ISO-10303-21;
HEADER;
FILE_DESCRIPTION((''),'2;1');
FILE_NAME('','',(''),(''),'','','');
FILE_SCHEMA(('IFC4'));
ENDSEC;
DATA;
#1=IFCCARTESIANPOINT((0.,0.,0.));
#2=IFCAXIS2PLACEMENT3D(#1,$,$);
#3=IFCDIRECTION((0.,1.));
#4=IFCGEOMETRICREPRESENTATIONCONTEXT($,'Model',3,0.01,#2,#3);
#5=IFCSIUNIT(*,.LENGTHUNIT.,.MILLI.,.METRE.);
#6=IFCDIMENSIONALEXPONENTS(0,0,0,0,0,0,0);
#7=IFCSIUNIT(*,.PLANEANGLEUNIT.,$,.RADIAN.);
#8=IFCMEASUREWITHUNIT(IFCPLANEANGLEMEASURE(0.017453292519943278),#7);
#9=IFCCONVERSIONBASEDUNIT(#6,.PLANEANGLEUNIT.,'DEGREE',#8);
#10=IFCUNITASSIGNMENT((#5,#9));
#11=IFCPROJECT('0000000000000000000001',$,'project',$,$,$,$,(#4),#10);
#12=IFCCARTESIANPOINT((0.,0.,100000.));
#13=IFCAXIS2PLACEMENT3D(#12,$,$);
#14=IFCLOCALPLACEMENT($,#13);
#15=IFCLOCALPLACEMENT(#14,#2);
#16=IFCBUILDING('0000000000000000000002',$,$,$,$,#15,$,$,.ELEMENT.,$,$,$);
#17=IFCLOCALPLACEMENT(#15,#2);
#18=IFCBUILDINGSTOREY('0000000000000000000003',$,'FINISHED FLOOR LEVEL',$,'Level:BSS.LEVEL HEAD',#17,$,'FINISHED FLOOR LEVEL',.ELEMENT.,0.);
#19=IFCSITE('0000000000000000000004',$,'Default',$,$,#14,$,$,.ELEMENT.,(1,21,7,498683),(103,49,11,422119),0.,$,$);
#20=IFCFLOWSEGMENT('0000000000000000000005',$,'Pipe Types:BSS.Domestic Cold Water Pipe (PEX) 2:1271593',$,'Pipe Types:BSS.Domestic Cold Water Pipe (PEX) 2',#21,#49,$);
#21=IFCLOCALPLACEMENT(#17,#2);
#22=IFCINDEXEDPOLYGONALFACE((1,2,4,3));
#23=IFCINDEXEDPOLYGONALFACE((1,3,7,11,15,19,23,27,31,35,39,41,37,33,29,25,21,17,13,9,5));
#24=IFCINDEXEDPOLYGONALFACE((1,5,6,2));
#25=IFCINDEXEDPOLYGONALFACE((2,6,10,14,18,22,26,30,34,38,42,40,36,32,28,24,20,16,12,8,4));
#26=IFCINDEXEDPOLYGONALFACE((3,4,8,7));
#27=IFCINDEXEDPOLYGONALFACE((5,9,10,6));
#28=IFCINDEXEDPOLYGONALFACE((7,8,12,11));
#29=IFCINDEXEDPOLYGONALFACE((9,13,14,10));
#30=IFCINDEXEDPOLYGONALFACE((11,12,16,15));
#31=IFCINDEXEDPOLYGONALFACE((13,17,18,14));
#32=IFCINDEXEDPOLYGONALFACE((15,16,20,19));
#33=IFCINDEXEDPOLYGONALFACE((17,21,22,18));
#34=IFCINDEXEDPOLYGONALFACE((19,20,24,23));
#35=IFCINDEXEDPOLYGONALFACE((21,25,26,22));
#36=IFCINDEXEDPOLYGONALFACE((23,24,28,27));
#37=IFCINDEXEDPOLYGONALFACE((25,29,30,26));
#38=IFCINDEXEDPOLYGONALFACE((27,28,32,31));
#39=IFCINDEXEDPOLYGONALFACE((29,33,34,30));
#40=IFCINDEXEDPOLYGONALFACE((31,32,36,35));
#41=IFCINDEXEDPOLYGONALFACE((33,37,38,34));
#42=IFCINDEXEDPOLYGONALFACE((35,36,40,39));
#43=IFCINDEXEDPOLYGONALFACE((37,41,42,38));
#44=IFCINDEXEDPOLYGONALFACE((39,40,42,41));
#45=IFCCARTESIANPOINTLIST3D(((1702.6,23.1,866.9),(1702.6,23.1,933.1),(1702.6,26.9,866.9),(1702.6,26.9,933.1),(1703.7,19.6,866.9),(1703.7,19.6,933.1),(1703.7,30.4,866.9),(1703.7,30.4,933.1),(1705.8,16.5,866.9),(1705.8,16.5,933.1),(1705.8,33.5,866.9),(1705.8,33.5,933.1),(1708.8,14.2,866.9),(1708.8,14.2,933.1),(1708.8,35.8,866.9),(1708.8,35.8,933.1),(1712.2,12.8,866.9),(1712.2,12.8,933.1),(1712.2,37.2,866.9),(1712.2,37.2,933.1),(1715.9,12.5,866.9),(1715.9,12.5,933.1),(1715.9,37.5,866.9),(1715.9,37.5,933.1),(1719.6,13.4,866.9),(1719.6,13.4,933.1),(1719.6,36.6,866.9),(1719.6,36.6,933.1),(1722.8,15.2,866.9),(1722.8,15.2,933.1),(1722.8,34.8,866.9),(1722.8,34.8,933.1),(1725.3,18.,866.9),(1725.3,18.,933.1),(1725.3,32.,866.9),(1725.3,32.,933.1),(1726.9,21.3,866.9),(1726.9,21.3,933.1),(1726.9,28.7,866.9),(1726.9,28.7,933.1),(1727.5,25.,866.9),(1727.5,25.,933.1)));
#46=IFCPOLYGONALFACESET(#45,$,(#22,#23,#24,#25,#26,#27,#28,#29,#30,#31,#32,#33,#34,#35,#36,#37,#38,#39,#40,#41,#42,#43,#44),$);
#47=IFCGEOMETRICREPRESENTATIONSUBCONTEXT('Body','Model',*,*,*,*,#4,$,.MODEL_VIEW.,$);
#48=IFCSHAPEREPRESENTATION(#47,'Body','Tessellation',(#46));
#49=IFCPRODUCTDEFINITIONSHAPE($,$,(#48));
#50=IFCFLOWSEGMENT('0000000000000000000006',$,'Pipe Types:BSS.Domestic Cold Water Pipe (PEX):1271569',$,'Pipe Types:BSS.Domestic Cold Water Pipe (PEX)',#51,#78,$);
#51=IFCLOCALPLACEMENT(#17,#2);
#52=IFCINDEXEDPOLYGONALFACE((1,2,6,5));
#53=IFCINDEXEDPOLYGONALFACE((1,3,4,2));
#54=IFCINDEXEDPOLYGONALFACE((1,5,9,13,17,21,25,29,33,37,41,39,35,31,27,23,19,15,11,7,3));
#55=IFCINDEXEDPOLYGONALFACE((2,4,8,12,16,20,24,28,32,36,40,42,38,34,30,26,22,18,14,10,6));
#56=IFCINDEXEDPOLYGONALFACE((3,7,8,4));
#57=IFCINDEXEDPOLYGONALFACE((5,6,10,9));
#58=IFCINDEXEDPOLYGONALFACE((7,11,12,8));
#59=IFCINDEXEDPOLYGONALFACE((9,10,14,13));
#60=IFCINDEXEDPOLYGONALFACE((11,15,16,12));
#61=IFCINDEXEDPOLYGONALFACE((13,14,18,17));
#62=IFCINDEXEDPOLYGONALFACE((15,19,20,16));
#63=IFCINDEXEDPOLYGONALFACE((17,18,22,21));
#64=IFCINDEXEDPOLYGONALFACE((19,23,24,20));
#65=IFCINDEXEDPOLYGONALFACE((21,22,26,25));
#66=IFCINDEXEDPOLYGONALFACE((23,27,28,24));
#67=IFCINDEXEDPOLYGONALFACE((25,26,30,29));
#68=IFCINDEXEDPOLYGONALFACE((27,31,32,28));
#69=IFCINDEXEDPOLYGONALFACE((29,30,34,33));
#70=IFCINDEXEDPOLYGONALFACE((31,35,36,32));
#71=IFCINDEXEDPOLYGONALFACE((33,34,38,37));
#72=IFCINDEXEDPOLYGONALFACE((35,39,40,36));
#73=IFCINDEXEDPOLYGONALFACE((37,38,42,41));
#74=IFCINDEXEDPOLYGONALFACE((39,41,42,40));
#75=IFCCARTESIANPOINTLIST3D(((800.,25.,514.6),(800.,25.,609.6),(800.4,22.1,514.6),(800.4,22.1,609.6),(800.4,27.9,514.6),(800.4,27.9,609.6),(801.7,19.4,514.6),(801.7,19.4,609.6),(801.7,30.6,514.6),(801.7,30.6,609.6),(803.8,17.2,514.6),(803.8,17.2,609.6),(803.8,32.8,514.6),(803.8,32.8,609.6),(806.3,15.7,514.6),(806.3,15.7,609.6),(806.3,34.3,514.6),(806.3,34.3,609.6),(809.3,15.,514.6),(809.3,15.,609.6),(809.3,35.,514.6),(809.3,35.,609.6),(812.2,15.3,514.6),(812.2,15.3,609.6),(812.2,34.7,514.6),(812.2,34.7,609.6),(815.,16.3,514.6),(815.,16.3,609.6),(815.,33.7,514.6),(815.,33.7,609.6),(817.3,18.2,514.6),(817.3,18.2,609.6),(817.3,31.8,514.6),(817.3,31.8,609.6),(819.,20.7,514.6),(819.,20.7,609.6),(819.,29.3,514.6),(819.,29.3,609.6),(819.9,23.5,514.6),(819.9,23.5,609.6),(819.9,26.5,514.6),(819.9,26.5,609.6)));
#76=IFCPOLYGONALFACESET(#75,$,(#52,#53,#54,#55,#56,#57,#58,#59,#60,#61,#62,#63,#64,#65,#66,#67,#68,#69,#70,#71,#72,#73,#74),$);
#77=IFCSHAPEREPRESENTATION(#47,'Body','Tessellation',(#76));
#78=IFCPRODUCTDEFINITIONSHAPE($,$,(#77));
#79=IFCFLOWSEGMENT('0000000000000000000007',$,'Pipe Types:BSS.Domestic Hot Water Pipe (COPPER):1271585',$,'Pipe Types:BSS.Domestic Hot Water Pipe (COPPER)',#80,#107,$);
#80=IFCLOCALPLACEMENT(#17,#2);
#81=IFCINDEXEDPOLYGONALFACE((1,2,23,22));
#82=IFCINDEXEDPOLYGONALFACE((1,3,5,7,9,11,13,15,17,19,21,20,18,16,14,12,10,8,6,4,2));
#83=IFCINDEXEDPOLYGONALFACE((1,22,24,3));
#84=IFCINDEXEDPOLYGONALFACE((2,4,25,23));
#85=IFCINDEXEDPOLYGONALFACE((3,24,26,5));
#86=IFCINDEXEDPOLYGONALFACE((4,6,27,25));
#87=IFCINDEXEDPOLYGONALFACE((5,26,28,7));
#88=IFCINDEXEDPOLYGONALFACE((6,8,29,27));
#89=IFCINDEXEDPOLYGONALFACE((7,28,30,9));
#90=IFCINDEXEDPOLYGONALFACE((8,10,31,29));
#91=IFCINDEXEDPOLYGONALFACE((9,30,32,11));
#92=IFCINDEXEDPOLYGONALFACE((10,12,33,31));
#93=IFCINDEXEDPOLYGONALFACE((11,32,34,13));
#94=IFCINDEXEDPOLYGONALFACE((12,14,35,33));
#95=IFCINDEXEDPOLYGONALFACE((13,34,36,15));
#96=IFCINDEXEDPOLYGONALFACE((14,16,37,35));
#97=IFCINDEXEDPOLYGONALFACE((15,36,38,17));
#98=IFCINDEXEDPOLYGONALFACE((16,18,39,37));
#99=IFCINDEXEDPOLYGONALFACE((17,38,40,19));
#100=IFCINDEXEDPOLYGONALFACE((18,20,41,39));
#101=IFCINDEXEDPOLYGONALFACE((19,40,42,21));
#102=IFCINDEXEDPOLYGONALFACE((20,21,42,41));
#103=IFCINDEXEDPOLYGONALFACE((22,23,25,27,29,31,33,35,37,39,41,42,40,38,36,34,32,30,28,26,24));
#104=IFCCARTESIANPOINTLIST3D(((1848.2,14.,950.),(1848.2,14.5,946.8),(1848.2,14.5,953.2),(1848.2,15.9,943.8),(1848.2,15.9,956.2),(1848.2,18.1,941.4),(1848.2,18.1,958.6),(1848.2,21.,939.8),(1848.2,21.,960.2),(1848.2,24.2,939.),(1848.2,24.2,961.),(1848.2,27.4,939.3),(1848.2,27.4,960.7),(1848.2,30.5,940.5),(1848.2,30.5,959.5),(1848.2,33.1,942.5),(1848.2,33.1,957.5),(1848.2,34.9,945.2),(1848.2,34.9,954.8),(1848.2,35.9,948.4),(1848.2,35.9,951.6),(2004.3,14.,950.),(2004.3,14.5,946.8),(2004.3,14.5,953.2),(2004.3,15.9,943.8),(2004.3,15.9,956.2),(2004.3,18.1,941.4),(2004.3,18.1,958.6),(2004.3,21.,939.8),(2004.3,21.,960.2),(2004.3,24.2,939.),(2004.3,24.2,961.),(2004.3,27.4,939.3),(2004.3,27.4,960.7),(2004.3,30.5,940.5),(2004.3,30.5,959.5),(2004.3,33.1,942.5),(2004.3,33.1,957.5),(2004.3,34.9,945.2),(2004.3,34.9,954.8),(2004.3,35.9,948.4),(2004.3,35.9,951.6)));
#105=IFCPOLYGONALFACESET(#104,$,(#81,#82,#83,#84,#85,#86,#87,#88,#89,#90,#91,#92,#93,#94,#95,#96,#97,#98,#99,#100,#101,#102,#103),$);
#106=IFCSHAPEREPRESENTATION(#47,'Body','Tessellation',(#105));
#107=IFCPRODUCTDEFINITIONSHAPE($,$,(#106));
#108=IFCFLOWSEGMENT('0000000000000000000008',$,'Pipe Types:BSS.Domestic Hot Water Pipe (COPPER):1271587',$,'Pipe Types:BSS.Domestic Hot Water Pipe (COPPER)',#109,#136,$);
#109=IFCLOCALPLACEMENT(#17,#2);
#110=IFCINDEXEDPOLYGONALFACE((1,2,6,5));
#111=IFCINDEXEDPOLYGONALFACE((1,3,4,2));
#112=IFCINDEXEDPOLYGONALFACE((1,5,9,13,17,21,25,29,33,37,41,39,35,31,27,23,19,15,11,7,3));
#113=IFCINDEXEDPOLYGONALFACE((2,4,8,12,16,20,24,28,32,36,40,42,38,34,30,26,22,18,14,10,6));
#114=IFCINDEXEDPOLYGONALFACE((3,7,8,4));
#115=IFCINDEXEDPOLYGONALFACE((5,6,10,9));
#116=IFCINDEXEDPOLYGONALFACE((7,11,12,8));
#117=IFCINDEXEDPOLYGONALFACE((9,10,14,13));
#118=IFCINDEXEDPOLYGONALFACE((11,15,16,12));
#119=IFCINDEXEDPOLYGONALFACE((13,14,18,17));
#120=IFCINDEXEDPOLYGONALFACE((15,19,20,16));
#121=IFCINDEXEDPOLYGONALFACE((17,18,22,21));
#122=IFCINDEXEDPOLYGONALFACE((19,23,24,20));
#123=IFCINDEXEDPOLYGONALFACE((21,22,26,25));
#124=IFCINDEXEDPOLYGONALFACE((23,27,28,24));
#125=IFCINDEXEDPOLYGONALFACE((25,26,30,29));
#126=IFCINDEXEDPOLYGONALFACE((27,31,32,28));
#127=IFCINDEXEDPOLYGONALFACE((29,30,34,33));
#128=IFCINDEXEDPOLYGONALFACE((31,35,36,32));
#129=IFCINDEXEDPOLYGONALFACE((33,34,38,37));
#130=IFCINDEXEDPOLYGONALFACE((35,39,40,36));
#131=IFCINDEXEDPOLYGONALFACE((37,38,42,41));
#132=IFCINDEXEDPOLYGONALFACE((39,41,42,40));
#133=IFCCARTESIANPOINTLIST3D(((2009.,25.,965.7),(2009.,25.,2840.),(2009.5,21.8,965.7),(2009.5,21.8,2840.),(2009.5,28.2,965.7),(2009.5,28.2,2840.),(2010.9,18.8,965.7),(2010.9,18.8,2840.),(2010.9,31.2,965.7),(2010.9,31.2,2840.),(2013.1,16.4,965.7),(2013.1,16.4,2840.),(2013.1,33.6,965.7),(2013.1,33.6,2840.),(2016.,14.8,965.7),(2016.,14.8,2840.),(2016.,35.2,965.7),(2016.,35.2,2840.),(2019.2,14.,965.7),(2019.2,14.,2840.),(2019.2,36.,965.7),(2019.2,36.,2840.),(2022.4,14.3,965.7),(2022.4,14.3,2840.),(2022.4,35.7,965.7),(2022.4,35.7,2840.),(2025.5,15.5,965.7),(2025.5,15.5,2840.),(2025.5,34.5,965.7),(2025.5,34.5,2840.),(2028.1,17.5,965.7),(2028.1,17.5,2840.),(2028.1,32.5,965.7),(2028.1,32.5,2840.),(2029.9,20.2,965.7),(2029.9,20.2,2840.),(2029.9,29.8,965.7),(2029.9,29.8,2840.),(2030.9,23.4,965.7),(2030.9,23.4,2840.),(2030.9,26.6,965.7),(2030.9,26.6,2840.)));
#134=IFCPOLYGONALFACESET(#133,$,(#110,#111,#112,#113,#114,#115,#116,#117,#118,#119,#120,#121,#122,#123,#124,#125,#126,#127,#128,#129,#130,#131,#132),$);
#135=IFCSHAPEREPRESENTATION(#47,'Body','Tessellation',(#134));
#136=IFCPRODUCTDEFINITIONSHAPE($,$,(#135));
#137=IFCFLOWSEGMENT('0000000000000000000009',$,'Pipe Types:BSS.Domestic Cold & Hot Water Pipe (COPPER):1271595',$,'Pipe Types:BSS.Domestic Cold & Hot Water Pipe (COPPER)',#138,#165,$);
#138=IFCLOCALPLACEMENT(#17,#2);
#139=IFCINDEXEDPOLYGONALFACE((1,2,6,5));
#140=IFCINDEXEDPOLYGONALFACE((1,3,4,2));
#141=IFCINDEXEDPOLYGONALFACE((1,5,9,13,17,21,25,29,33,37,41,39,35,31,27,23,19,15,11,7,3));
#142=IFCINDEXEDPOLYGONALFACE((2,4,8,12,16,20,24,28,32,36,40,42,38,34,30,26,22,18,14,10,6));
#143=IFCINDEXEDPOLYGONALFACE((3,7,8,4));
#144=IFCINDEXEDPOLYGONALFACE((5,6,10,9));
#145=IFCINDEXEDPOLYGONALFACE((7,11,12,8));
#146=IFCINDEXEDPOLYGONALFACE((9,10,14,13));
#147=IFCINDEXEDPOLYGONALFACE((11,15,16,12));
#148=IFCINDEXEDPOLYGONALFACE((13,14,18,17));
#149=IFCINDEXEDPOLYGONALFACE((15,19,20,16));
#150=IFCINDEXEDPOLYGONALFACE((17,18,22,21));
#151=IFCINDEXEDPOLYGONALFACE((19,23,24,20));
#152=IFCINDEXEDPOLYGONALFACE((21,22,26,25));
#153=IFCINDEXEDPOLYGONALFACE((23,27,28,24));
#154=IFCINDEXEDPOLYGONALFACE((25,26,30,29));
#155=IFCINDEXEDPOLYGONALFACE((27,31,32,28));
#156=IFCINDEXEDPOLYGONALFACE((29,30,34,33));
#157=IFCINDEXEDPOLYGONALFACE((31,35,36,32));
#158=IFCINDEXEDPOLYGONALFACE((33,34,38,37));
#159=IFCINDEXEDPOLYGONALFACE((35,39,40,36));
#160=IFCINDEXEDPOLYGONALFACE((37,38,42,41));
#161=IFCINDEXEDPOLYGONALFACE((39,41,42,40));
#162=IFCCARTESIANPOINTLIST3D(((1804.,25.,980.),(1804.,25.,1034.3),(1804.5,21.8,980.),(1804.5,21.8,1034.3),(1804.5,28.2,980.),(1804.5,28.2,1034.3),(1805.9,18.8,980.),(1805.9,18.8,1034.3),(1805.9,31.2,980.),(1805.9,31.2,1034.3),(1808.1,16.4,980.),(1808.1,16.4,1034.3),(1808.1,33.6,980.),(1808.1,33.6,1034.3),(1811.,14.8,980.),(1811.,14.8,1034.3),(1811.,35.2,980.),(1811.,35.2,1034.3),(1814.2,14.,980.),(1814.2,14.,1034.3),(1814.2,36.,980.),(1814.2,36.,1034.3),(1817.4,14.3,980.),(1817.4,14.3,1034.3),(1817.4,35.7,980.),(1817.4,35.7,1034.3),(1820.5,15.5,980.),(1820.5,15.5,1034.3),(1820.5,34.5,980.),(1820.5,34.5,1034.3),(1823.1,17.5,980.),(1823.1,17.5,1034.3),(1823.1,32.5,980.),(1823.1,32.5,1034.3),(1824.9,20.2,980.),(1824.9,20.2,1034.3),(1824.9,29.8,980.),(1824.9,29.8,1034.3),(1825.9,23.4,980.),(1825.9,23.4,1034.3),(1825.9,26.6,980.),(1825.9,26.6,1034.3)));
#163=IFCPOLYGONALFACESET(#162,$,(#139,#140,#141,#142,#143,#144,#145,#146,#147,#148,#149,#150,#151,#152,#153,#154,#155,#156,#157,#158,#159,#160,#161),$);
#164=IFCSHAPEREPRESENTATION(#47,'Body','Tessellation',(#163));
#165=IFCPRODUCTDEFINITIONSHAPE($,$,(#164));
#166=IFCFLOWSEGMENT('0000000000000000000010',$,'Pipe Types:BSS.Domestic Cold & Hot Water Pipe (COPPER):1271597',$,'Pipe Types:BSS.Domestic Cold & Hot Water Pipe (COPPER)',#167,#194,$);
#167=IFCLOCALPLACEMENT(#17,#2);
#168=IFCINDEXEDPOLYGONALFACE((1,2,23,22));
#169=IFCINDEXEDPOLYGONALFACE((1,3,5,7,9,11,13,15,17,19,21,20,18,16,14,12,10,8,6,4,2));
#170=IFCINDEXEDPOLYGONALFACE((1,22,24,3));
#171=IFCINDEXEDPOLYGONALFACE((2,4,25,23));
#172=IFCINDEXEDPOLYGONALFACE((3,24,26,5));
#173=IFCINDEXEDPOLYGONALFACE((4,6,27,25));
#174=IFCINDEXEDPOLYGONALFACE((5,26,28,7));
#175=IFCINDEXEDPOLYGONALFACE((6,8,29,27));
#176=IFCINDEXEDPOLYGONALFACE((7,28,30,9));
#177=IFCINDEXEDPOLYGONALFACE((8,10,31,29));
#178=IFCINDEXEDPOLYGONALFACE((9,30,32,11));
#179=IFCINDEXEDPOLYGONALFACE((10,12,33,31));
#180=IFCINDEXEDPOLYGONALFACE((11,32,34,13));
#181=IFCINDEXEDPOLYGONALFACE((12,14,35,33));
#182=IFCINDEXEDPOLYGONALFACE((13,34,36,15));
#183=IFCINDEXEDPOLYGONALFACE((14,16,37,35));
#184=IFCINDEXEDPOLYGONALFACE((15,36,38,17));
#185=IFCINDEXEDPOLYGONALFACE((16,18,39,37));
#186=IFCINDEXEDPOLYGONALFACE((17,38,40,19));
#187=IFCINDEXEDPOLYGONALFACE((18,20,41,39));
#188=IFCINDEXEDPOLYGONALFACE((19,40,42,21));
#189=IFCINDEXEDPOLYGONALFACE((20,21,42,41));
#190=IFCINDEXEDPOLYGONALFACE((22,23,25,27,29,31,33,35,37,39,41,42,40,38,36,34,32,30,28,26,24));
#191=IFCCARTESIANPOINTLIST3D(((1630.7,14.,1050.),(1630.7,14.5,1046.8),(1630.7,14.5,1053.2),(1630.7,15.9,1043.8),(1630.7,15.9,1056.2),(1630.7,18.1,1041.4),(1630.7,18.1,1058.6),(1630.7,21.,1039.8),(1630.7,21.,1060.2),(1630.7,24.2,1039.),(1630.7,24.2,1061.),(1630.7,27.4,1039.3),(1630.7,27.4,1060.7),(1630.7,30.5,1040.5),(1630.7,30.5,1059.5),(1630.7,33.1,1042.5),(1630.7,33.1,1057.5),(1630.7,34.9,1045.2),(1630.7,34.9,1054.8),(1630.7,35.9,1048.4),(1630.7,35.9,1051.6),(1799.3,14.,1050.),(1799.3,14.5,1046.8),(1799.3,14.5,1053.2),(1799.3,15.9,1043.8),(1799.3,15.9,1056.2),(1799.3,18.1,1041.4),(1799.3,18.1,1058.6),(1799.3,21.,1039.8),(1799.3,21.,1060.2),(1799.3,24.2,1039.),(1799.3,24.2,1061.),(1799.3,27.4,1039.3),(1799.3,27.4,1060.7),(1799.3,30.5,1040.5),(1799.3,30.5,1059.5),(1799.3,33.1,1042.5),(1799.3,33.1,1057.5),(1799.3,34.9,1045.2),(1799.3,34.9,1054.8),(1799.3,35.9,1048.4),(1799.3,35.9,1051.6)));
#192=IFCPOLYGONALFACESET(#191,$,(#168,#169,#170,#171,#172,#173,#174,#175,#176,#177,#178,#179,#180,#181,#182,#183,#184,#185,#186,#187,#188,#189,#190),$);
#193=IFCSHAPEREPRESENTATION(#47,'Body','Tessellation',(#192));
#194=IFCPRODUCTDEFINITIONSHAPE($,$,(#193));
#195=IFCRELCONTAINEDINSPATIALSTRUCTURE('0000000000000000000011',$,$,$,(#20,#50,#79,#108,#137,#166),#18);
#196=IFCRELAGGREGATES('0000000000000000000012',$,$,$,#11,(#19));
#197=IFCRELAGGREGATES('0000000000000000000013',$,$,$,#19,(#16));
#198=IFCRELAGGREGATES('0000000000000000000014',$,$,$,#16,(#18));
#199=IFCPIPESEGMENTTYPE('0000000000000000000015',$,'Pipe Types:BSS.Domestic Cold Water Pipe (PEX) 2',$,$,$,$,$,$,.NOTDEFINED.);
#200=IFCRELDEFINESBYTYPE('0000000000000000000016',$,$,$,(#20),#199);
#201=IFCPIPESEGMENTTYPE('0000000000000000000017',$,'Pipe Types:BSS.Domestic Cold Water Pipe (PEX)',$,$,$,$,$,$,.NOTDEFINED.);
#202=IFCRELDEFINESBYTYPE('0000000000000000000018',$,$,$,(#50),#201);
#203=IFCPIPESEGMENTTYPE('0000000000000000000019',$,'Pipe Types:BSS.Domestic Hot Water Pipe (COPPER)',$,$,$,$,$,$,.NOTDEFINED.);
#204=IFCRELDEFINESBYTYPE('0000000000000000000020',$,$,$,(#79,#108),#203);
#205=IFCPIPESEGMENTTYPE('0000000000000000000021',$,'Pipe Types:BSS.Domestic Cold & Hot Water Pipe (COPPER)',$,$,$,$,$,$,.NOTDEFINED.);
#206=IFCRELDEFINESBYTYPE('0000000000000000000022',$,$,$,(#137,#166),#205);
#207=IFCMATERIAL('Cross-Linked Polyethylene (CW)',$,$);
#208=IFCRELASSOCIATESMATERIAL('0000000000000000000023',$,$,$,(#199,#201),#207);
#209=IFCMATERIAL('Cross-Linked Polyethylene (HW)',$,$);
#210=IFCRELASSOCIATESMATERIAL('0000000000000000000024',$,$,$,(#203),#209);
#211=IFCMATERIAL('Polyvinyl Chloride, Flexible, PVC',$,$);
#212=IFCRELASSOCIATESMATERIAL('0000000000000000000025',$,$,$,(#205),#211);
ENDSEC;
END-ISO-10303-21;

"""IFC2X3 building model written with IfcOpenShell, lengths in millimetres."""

from ifc_helpers import new_model, entity, si_unit, converted_unit, direction, frame, frame_2d, origin, place, context, subcontext, project, spatial, circle, extrude, material, type_object, element, save


model = new_model("IFC2X3")

# Units and contexts
model_context = context("Model", 3, precision=0.01, world=origin(), true_north=direction((0.0, 1.0)))
body_context = subcontext(model_context, "Body", "Model", "MODEL_VIEW")
ifc_project = project(units=[si_unit("LENGTHUNIT", "METRE", prefix="MILLI"), converted_unit("PLANEANGLEUNIT", "DEGREE", entity("IfcPlaneAngleMeasure", 0.017453292519943278), si_unit("PLANEANGLEUNIT", "RADIAN"), dimensions=[0, 0, 0, 0, 0, 0, 0])], contexts=[model_context])

# Site, building, storey
site_placement = place(None, frame((0.0, 0.0, 100000.0)))
site = spatial("IfcSite", under=ifc_project, at=site_placement, Name="Default", CompositionType="ELEMENT", RefLatitude=(1, 21, 7, 498683), RefLongitude=(103, 49, 11, 422119), RefElevation=0.0)
building_placement = place(site_placement, origin())
building = spatial("IfcBuilding", under=site, at=building_placement, CompositionType="ELEMENT")
storey_placement = place(building_placement, origin())
storey = spatial("IfcBuildingStorey", under=building, at=storey_placement, Name="FINISHED FLOOR LEVEL", ObjectType="Level:BSS.LEVEL HEAD", LongName="FINISHED FLOOR LEVEL", CompositionType="ELEMENT", Elevation=0.0)

# Flow segments
ifc_material_1 = material(Name="Polyvinyl Chloride, Flexible, PVC")
ifc_material_2 = material(Name="Cross-Linked Polyethylene (CW)")
pipe_segment_type_1 = type_object("IfcPipeSegmentType", Name="Pipe Types:BSS.Domestic Cold Water Pipe (PEX) 2", PredefinedType="NOTDEFINED", material=ifc_material_2)
flow_segment_1_placement = place(storey_placement, origin())
element("IfcFlowSegment", 1, at=flow_segment_1_placement, inside=storey, type_object=pipe_segment_type_1, Name="Pipe Types:BSS.Domestic Cold Water Pipe (PEX) 2:1271593", ObjectType="Pipe Types:BSS.Domestic Cold Water Pipe (PEX) 2", context=body_context, shape_type="SweptSolid", body=[
    extrude(circle(Radius=12.5, at=frame_2d((0.0, 0.0), x_axis=(1.0, 0.0))), frame((1715.0, 25.0, 866.9)), (0.0, 0.0, 1.0), 66.1),
])
pipe_segment_type_2 = type_object("IfcPipeSegmentType", Name="Pipe Types:BSS.Domestic Cold Water Pipe (PEX)", PredefinedType="NOTDEFINED", material=ifc_material_2)
flow_segment_2_placement = place(storey_placement, origin())
element("IfcFlowSegment", 2, at=flow_segment_2_placement, inside=storey, type_object=pipe_segment_type_2, Name="Pipe Types:BSS.Domestic Cold Water Pipe (PEX):1271569", ObjectType="Pipe Types:BSS.Domestic Cold Water Pipe (PEX)", context=body_context, shape_type="SweptSolid", body=[
    extrude(circle(Radius=10.0, at=frame_2d((0.0, 0.0), x_axis=(1.0, 0.0))), frame((810.0, 25.0, 514.6), z_axis=(0.0, 0.0, 1.0), x_axis=(-1.0, 0.0, 0.0)), (0.0, 0.0, 1.0), 95.0),
])
ifc_material_3 = material(Name="Cross-Linked Polyethylene (HW)")
pipe_segment_type_3 = type_object("IfcPipeSegmentType", Name="Pipe Types:BSS.Domestic Hot Water Pipe (COPPER)", PredefinedType="NOTDEFINED", material=ifc_material_3)
flow_segment_3_placement = place(storey_placement, origin())
element("IfcFlowSegment", 3, at=flow_segment_3_placement, inside=storey, type_object=pipe_segment_type_3, Name="Pipe Types:BSS.Domestic Hot Water Pipe (COPPER):1271585", ObjectType="Pipe Types:BSS.Domestic Hot Water Pipe (COPPER)", context=body_context, shape_type="SweptSolid", body=[
    extrude(circle(Radius=11.0, at=frame_2d((0.0, 0.0), x_axis=(1.0, 0.0))), frame((1848.2, 25.0, 950.0), z_axis=(1.0, 0.0, 0.0), x_axis=(0.0, -1.0, 0.0)), (0.0, 0.0, 1.0), 156.1),
])
flow_segment_4_placement = place(storey_placement, origin())
element("IfcFlowSegment", 4, at=flow_segment_4_placement, inside=storey, type_object=pipe_segment_type_3, Name="Pipe Types:BSS.Domestic Hot Water Pipe (COPPER):1271587", ObjectType="Pipe Types:BSS.Domestic Hot Water Pipe (COPPER)", context=body_context, shape_type="SweptSolid", body=[
    extrude(circle(Radius=11.0, at=frame_2d((0.0, 0.0), x_axis=(1.0, 0.0))), frame((2020.0, 25.0, 965.7), z_axis=(0.0, 0.0, 1.0), x_axis=(-1.0, 0.0, 0.0)), (0.0, 0.0, 1.0), 1874.3),
])
pipe_segment_type_4 = type_object("IfcPipeSegmentType", Name="Pipe Types:BSS.Domestic Cold & Hot Water Pipe (COPPER)", PredefinedType="NOTDEFINED", material=ifc_material_1)
flow_segment_5_placement = place(storey_placement, origin())
element("IfcFlowSegment", 5, at=flow_segment_5_placement, inside=storey, type_object=pipe_segment_type_4, Name="Pipe Types:BSS.Domestic Cold & Hot Water Pipe (COPPER):1271595", ObjectType="Pipe Types:BSS.Domestic Cold & Hot Water Pipe (COPPER)", context=body_context, shape_type="SweptSolid", body=[
    extrude(circle(Radius=11.0, at=frame_2d((0.0, 0.0), x_axis=(1.0, 0.0))), frame((1815.0, 25.0, 980.0), z_axis=(0.0, -0.000001, 1.0), x_axis=(-1.0, 0.0, 0.0)), (0.0, 0.0, 1.0), 54.3),
])
flow_segment_6_placement = place(storey_placement, origin())
element("IfcFlowSegment", 6, at=flow_segment_6_placement, inside=storey, type_object=pipe_segment_type_4, Name="Pipe Types:BSS.Domestic Cold & Hot Water Pipe (COPPER):1271597", ObjectType="Pipe Types:BSS.Domestic Cold & Hot Water Pipe (COPPER)", context=body_context, shape_type="SweptSolid", body=[
    extrude(circle(Radius=11.0, at=frame_2d((0.0, 0.0), x_axis=(1.0, 0.0))), frame((1630.7, 25.0, 1050.0), z_axis=(1.0, -0.000001, 0.0), x_axis=(-0.000001, -1.0, 0.0)), (0.0, 0.0, 1.0), 168.7),
])

save(model, "model.ifc")
